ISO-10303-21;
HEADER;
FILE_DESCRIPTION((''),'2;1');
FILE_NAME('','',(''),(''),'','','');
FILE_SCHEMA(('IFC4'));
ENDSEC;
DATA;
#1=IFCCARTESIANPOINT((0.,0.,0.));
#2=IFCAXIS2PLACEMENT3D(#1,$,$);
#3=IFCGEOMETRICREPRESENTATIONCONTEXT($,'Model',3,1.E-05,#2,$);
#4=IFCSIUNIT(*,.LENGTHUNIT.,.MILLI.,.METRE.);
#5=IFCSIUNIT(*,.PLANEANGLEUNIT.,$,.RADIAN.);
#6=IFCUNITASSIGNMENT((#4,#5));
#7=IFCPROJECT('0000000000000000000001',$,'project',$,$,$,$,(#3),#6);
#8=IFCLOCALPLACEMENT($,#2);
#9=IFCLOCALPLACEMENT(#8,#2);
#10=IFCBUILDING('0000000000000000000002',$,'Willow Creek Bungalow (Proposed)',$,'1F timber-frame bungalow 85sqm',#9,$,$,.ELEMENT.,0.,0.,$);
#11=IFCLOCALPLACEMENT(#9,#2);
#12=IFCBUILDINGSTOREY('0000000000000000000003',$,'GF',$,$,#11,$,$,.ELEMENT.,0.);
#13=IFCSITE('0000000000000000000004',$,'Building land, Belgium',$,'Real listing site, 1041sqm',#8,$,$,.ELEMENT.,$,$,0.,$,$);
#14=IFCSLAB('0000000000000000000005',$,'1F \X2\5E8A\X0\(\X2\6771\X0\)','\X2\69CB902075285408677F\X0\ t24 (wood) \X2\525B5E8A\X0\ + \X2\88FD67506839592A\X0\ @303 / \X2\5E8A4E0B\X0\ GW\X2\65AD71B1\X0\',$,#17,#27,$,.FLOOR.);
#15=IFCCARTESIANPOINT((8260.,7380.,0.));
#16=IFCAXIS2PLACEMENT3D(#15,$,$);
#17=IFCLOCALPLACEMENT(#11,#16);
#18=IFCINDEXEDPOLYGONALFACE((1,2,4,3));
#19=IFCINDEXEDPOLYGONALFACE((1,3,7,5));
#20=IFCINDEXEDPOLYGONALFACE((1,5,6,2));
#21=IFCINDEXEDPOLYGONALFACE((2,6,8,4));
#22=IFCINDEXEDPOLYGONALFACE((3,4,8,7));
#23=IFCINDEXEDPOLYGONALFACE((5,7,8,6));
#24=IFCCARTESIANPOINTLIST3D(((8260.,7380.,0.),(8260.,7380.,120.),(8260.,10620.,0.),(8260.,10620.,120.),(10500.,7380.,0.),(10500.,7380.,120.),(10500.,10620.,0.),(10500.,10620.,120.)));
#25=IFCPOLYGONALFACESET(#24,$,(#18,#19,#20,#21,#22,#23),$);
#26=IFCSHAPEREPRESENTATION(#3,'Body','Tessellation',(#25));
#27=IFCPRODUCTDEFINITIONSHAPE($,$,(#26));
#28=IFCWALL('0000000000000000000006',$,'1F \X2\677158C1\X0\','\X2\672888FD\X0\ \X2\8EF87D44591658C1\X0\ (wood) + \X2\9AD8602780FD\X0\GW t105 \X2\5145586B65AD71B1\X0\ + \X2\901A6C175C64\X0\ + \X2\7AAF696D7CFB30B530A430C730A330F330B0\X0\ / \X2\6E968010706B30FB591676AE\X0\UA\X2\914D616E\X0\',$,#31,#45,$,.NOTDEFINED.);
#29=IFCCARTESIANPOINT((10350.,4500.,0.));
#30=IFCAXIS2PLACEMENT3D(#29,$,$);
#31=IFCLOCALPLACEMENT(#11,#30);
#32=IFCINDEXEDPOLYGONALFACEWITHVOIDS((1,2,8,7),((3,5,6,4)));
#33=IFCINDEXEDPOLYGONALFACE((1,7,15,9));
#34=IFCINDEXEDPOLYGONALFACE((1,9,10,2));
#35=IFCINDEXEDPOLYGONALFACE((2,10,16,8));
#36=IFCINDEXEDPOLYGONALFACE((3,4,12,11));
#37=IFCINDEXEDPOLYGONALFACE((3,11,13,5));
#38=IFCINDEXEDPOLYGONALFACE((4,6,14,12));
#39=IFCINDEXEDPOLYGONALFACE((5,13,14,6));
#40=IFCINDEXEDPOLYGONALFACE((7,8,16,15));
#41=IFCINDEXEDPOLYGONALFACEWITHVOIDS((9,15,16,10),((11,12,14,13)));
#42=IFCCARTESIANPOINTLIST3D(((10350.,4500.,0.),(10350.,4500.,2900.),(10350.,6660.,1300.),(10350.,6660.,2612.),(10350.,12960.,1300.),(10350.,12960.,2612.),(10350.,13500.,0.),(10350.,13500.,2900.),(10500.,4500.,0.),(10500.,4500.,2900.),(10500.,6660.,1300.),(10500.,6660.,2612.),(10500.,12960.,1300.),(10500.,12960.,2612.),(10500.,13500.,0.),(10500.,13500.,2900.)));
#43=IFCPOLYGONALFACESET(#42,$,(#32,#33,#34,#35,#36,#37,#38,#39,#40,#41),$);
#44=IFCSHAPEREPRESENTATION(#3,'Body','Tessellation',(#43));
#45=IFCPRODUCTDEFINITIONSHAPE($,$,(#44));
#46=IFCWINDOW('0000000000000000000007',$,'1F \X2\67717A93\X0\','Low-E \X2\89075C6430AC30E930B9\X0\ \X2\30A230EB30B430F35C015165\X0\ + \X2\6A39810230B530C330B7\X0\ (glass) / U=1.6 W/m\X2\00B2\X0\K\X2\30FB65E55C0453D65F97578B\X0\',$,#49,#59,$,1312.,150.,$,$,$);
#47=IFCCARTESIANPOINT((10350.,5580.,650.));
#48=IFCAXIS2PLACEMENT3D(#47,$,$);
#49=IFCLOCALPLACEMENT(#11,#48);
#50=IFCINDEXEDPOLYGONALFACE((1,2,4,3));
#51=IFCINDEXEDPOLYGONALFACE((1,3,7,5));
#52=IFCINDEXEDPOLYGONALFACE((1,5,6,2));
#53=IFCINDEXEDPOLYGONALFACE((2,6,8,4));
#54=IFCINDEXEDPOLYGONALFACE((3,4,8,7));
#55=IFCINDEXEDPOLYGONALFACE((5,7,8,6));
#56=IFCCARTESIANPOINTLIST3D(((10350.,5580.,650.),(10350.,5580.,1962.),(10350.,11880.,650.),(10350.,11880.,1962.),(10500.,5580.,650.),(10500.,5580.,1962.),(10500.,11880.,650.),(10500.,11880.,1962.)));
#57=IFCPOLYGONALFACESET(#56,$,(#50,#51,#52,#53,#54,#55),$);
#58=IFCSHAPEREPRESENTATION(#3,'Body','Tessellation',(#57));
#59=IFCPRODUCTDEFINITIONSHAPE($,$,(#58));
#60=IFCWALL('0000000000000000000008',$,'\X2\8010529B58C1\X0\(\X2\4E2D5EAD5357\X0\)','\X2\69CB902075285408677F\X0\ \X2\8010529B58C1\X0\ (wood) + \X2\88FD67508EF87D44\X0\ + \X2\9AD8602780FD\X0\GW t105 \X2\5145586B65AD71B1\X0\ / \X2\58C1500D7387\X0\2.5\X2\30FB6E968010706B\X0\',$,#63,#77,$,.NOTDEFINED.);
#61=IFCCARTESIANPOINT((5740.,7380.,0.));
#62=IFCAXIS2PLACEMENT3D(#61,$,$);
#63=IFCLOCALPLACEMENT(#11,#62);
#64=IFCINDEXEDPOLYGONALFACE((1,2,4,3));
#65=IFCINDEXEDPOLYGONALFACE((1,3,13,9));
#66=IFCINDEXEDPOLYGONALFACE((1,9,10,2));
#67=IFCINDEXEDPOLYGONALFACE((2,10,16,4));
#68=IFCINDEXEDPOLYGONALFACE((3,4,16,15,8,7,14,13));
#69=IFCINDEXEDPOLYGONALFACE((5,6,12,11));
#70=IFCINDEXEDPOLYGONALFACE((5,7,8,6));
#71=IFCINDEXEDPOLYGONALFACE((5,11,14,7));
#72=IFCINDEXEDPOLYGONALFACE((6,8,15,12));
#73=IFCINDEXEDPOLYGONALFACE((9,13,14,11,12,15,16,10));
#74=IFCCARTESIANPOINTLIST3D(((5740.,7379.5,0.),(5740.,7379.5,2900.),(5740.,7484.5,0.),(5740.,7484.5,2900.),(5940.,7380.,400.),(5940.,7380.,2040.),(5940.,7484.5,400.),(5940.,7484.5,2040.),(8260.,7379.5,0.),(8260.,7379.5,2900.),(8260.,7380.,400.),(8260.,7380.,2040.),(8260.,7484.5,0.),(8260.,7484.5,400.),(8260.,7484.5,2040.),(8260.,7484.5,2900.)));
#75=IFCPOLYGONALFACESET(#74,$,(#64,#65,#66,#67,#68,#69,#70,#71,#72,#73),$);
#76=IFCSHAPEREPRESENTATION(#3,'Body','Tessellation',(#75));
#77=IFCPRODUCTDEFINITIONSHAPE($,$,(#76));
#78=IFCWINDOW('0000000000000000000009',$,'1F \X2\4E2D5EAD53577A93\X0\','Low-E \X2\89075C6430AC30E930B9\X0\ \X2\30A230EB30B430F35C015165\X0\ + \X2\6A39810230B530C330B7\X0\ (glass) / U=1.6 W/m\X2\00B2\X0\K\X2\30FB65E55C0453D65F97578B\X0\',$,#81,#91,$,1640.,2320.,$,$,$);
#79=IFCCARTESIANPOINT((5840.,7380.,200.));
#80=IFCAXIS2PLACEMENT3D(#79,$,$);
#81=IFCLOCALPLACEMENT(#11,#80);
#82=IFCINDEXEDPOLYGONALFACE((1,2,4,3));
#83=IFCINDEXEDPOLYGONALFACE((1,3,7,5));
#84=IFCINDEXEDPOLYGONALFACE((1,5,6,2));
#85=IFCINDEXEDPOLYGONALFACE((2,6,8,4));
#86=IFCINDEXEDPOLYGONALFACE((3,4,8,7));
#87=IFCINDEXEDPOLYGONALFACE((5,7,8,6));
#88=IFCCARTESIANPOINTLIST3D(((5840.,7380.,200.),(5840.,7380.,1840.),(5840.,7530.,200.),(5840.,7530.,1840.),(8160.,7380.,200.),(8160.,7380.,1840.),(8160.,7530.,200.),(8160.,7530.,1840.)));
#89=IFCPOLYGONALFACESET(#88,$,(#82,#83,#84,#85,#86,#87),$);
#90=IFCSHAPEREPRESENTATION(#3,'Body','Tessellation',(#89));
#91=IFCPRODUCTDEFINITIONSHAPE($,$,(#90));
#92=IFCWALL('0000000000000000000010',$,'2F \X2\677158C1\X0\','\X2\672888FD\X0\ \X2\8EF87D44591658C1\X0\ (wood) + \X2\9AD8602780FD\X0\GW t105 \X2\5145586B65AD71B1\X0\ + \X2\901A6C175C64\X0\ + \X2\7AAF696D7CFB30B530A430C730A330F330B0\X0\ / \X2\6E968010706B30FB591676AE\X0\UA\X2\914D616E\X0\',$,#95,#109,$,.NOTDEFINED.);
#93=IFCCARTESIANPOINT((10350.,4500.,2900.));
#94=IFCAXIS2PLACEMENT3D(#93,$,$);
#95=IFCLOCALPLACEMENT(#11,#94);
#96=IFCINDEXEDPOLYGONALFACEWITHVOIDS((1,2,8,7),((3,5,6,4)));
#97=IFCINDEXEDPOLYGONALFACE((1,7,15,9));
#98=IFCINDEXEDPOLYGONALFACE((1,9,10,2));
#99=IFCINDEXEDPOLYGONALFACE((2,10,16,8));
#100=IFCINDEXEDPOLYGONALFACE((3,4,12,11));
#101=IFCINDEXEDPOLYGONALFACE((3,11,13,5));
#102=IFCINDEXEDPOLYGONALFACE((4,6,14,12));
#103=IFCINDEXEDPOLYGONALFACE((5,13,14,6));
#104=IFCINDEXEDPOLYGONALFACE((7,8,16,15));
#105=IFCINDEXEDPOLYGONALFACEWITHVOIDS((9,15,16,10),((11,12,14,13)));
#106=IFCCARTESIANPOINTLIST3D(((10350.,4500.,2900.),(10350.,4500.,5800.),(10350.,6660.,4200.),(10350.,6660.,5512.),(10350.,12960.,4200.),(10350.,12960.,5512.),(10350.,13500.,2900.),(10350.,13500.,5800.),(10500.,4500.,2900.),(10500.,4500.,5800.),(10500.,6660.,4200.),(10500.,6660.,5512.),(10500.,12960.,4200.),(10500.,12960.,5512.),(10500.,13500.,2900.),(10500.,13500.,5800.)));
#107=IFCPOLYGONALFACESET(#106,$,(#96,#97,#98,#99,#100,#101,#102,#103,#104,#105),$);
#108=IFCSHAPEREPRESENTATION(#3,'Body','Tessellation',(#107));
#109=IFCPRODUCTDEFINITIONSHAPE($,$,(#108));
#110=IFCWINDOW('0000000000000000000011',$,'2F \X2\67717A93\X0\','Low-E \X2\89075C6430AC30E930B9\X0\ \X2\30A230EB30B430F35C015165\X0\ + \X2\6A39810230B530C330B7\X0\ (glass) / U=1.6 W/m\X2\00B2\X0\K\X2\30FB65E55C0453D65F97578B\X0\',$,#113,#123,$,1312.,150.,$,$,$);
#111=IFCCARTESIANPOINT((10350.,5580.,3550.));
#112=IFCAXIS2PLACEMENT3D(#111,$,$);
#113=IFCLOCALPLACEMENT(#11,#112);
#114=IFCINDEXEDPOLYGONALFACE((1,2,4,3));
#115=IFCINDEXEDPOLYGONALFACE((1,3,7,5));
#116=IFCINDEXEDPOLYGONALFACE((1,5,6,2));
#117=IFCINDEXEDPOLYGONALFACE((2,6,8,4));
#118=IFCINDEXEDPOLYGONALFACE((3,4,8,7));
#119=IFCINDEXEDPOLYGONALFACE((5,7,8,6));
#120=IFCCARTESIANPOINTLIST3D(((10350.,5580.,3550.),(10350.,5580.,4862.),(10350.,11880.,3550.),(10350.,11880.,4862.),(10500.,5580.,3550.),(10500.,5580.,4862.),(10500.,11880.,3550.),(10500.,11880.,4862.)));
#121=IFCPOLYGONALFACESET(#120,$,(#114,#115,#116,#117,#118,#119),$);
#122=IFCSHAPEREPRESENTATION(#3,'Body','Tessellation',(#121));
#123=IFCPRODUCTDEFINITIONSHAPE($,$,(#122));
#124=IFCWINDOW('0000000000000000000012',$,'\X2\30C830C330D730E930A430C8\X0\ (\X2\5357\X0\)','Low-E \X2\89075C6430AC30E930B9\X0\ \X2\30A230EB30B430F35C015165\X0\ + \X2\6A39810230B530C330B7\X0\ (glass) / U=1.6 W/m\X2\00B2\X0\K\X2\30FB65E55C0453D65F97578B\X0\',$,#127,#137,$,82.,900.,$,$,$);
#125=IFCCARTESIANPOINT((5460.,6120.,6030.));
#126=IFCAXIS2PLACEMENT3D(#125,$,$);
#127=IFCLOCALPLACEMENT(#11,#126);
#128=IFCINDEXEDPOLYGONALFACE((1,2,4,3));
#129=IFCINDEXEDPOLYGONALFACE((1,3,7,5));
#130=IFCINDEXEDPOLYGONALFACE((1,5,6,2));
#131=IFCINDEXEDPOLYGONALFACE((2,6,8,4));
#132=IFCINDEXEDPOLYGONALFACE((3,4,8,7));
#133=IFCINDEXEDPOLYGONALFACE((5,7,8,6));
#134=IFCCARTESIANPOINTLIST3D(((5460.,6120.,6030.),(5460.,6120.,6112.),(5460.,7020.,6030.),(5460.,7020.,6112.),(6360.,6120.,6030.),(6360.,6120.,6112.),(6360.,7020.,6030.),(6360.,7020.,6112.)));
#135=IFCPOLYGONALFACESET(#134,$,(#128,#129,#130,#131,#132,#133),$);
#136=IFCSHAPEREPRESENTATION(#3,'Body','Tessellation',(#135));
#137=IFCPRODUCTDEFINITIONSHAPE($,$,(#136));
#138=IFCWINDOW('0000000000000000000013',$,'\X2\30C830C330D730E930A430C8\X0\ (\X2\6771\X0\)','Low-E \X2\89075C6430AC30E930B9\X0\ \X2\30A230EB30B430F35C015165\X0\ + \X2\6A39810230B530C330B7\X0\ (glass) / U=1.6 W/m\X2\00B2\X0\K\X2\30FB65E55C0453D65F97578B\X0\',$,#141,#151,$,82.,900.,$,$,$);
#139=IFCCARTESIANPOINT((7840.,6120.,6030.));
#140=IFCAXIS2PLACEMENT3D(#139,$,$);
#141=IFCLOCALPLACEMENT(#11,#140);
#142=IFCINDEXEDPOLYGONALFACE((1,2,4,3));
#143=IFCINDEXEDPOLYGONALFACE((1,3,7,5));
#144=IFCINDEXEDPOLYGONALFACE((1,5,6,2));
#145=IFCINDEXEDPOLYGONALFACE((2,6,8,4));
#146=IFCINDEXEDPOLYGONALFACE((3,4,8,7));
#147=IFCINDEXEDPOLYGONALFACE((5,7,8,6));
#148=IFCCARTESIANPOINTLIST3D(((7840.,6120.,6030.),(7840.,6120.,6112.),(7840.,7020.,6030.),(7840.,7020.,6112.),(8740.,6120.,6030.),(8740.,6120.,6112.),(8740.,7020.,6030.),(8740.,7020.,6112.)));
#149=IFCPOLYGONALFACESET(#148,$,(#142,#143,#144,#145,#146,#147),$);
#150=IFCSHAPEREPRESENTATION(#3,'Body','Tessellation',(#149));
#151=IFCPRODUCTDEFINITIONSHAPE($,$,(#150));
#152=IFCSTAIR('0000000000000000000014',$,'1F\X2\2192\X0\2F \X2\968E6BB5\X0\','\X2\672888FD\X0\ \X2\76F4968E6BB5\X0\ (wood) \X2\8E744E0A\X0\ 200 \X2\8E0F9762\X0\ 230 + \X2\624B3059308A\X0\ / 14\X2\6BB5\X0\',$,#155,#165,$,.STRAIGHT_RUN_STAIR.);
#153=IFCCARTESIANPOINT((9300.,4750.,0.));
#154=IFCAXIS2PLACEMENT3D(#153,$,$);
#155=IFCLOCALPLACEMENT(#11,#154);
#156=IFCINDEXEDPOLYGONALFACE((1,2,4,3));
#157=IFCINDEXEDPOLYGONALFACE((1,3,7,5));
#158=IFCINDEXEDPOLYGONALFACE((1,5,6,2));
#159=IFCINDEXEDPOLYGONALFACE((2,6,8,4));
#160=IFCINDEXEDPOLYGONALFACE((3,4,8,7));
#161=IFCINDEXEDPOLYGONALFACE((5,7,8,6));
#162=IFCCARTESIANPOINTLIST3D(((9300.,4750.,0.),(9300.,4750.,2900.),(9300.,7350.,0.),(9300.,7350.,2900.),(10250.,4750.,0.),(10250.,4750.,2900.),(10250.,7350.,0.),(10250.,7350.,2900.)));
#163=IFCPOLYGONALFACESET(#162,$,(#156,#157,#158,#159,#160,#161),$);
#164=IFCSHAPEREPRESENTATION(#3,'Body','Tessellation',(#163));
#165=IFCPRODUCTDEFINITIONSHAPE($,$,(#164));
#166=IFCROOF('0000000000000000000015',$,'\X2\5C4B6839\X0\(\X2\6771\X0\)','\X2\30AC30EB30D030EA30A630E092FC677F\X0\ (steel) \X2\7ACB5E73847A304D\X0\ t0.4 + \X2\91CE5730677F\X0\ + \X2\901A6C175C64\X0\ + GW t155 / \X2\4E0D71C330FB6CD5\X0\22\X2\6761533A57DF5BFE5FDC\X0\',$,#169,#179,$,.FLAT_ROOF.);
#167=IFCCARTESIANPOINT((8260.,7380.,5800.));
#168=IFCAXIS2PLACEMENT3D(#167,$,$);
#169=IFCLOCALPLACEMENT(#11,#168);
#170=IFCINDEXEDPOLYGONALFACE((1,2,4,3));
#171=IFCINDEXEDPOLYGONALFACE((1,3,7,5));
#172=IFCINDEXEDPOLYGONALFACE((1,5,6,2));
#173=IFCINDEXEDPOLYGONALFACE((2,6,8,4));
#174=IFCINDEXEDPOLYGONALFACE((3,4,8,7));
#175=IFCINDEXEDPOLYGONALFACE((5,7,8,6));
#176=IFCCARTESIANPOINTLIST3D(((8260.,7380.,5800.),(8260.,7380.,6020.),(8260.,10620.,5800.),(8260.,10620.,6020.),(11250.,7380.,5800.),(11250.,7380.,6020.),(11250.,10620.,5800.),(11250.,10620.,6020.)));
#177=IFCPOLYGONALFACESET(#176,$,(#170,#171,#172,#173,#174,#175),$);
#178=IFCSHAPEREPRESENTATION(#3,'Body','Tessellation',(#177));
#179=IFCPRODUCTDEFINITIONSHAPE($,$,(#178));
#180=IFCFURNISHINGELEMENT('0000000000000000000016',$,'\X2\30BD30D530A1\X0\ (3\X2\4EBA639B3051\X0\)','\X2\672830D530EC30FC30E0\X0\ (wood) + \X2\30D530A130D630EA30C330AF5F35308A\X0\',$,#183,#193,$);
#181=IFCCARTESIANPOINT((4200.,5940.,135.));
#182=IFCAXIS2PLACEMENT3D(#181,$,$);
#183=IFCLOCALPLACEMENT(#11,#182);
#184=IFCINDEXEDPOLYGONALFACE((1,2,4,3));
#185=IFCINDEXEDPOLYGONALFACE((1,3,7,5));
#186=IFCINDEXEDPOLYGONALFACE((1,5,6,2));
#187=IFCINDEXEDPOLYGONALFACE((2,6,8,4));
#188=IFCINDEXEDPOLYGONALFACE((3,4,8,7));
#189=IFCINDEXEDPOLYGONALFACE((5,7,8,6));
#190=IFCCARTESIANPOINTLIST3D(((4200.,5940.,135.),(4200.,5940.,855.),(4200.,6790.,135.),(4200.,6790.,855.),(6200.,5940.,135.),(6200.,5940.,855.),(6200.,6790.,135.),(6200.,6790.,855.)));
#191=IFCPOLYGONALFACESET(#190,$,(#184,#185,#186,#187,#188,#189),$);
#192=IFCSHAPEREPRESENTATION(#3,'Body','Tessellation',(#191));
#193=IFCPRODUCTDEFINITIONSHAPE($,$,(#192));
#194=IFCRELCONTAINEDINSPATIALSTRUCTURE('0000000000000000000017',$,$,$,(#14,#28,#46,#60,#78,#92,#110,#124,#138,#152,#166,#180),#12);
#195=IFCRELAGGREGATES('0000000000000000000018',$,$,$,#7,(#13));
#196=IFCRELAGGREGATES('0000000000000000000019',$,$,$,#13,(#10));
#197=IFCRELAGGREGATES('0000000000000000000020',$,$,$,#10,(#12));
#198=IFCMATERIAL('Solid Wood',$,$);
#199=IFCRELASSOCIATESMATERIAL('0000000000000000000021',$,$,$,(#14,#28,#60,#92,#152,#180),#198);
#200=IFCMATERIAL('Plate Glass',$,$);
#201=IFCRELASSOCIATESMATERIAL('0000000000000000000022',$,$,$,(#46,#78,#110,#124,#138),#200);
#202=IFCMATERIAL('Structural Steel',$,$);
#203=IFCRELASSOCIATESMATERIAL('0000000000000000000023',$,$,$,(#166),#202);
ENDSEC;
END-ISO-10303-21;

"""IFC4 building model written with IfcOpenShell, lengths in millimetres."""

from ifc_helpers import new_model, si_unit, frame, frame_2d, origin, place, context, project, spatial, rectangle, extrude, material, element, fill, save


model = new_model("IFC4")

# Units and contexts
model_context = context("Model", 3, precision=1e-05, world=origin())
ifc_project = project(units=[si_unit("LENGTHUNIT", "METRE", prefix="MILLI"), si_unit("PLANEANGLEUNIT", "RADIAN")], contexts=[model_context])

# Site, building, storey
site_placement = place(None, origin())
site = spatial("IfcSite", under=ifc_project, at=site_placement, Name="Building land, Belgium", ObjectType="Real listing site, 1041sqm", CompositionType="ELEMENT", RefElevation=0.0)
building_placement = place(site_placement, origin())
building = spatial("IfcBuilding", under=site, at=building_placement, Name="Willow Creek Bungalow (Proposed)", ObjectType="1F timber-frame bungalow 85sqm", CompositionType="ELEMENT", ElevationOfRefHeight=0.0, ElevationOfTerrain=0.0)
storey_placement = place(building_placement, origin())
storey = spatial("IfcBuildingStorey", under=building, at=storey_placement, Name="GF", CompositionType="ELEMENT", Elevation=0.0)

# Slab
ifc_material_1 = material(Name="Solid Wood")
slab_placement = place(storey_placement, frame((8260.0, 7380.0, 0.0)))
element("IfcSlab", 1, at=slab_placement, inside=storey, material=ifc_material_1, Name="1F 床(東)", Description="構造用合板 t24 (wood) 剛床 + 製材根太 @303 / 床下 GW断熱", PredefinedType="FLOOR", context=model_context, shape_type="SweptSolid", body=[
    extrude(rectangle(XDim=2240.0, YDim=3240.0, at=frame_2d((1120.0, 1620.0))), frame((8260.0, 7380.0, 0.0)), (0.0, 0.0, 1.0), 120.0),
])

# Walls, openings, windows
wall_1_placement = place(storey_placement, frame((10350.0, 4500.0, 0.0)))
wall_1 = element("IfcWall", 2, at=wall_1_placement, inside=storey, material=ifc_material_1, Name="1F 東壁", Description="木製 軸組外壁 (wood) + 高性能GW t105 充填断熱 + 通気層 + 窯業系サイディング / 準耐火・外皮UA配慮", PredefinedType="NOTDEFINED", context=model_context, shape_type="SweptSolid", body=[
    extrude(rectangle(XDim=150.0, YDim=9000.0, at=frame_2d((75.0, 4500.0))), frame((10350.0, 4500.0, 0.0)), (0.0, 0.0, 1.0), 2900.0),
])
opening_1_placement = place(storey_placement, frame((10350.0, 5580.0, 650.0)))
opening_1 = element("IfcOpeningElement", 3, at=opening_1_placement, cuts=wall_1, PredefinedType="NOTDEFINED", context=model_context, shape_type="SweptSolid", body=[
    extrude(rectangle(XDim=150.0, YDim=6300.0, at=frame_2d((75.0, 3150.0))), frame((10350.0, 5580.0, 650.0)), (0.0, 0.0, 1.0), 1312.0),
])
ifc_material_2 = material(Name="Plate Glass")
window_1_placement = place(storey_placement, frame((10350.0, 5580.0, 650.0)))
window_1 = element("IfcWindow", 4, at=window_1_placement, inside=storey, material=ifc_material_2, Name="1F 東窓", Description="Low-E 複層ガラス アルゴン封入 + 樹脂サッシ (glass) / U=1.6 W/m²K・日射取得型", OverallHeight=1312.0, OverallWidth=150.0, context=model_context, shape_type="SweptSolid", body=[
    extrude(rectangle(XDim=150.0, YDim=6300.0, at=frame_2d((75.0, 3150.0))), frame((10350.0, 5580.0, 650.0)), (0.0, 0.0, 1.0), 1312.0),
])
fill(opening_1, window_1)
wall_2_placement = place(storey_placement, frame((5740.0, 7380.0, 0.0)))
wall_2 = element("IfcWall", 5, at=wall_2_placement, inside=storey, material=ifc_material_1, Name="耐力壁(中庭南)", Description="構造用合板 耐力壁 (wood) + 製材軸組 + 高性能GW t105 充填断熱 / 壁倍率2.5・準耐火", PredefinedType="NOTDEFINED", context=model_context, shape_type="SweptSolid", body=[
    extrude(rectangle(XDim=2520.0, YDim=105.0, at=frame_2d((1260.0, 52.0))), frame((5740.0, 7380.0, 0.0)), (0.0, 0.0, 1.0), 2900.0),
])
opening_2_placement = place(storey_placement, frame((5840.0, 7380.0, 200.0)))
opening_2 = element("IfcOpeningElement", 6, at=opening_2_placement, cuts=wall_2, PredefinedType="NOTDEFINED", context=model_context, shape_type="SweptSolid", body=[
    extrude(rectangle(XDim=2320.0, YDim=150.0, at=frame_2d((1160.0, 75.0))), frame((5840.0, 7380.0, 200.0)), (0.0, 0.0, 1.0), 1640.0),
])
window_2_placement = place(storey_placement, frame((5840.0, 7380.0, 200.0)))
window_2 = element("IfcWindow", 7, at=window_2_placement, inside=storey, material=ifc_material_2, Name="1F 中庭南窓", Description="Low-E 複層ガラス アルゴン封入 + 樹脂サッシ (glass) / U=1.6 W/m²K・日射取得型", OverallHeight=1640.0, OverallWidth=2320.0, context=model_context, shape_type="SweptSolid", body=[
    extrude(rectangle(XDim=2320.0, YDim=150.0, at=frame_2d((1160.0, 75.0))), frame((5840.0, 7380.0, 200.0)), (0.0, 0.0, 1.0), 1640.0),
])
fill(opening_2, window_2)

# Wall, opening, window
wall_3_placement = place(storey_placement, frame((10350.0, 4500.0, 2900.0)))
wall_3 = element("IfcWall", 8, at=wall_3_placement, inside=storey, material=ifc_material_1, Name="2F 東壁", Description="木製 軸組外壁 (wood) + 高性能GW t105 充填断熱 + 通気層 + 窯業系サイディング / 準耐火・外皮UA配慮", PredefinedType="NOTDEFINED", context=model_context, shape_type="SweptSolid", body=[
    extrude(rectangle(XDim=150.0, YDim=9000.0, at=frame_2d((75.0, 4500.0))), frame((10350.0, 4500.0, 2900.0)), (0.0, 0.0, 1.0), 2900.0),
])
opening_3_placement = place(storey_placement, frame((10350.0, 5580.0, 3550.0)))
opening_3 = element("IfcOpeningElement", 9, at=opening_3_placement, cuts=wall_3, PredefinedType="NOTDEFINED", context=model_context, shape_type="SweptSolid", body=[
    extrude(rectangle(XDim=150.0, YDim=6300.0, at=frame_2d((75.0, 3150.0))), frame((10350.0, 5580.0, 3550.0)), (0.0, 0.0, 1.0), 1312.0),
])
window_3_placement = place(storey_placement, frame((10350.0, 5580.0, 3550.0)))
window_3 = element("IfcWindow", 10, at=window_3_placement, inside=storey, material=ifc_material_2, Name="2F 東窓", Description="Low-E 複層ガラス アルゴン封入 + 樹脂サッシ (glass) / U=1.6 W/m²K・日射取得型", OverallHeight=1312.0, OverallWidth=150.0, context=model_context, shape_type="SweptSolid", body=[
    extrude(rectangle(XDim=150.0, YDim=6300.0, at=frame_2d((75.0, 3150.0))), frame((10350.0, 5580.0, 3550.0)), (0.0, 0.0, 1.0), 1312.0),
])
fill(opening_3, window_3)

# Windows
window_4_placement = place(storey_placement, frame((5460.0, 6120.0, 6030.0)))
element("IfcWindow", 11, at=window_4_placement, inside=storey, material=ifc_material_2, Name="トップライト (南)", Description="Low-E 複層ガラス アルゴン封入 + 樹脂サッシ (glass) / U=1.6 W/m²K・日射取得型", OverallHeight=82.0, OverallWidth=900.0, context=model_context, shape_type="SweptSolid", body=[
    extrude(rectangle(XDim=900.0, YDim=900.0, at=frame_2d((450.0, 450.0))), frame((5460.0, 6120.0, 6030.0)), (0.0, 0.0, 1.0), 82.0),
])
window_5_placement = place(storey_placement, frame((7840.0, 6120.0, 6030.0)))
element("IfcWindow", 12, at=window_5_placement, inside=storey, material=ifc_material_2, Name="トップライト (東)", Description="Low-E 複層ガラス アルゴン封入 + 樹脂サッシ (glass) / U=1.6 W/m²K・日射取得型", OverallHeight=82.0, OverallWidth=900.0, context=model_context, shape_type="SweptSolid", body=[
    extrude(rectangle(XDim=900.0, YDim=900.0, at=frame_2d((450.0, 450.0))), frame((7840.0, 6120.0, 6030.0)), (0.0, 0.0, 1.0), 82.0),
])

# Stair
stair_placement = place(storey_placement, frame((9300.0, 4750.0, 0.0)))
element("IfcStair", 13, at=stair_placement, inside=storey, material=ifc_material_1, Name="1F→2F 階段", Description="木製 直階段 (wood) 蹴上 200 踏面 230 + 手すり / 14段", PredefinedType="STRAIGHT_RUN_STAIR", context=model_context, shape_type="SweptSolid", body=[
    extrude(rectangle(XDim=950.0, YDim=2600.0, at=frame_2d((475.0, 1300.0))), frame((9300.0, 4750.0, 0.0)), (0.0, 0.0, 1.0), 2900.0),
])

# Roof
ifc_material_3 = material(Name="Structural Steel")
roof_placement = place(storey_placement, frame((8260.0, 7380.0, 5800.0)))
element("IfcRoof", 14, at=roof_placement, inside=storey, material=ifc_material_3, Name="屋根(東)", Description="ガルバリウム鋼板 (steel) 立平葺き t0.4 + 野地板 + 通気層 + GW t155 / 不燃・法22条区域対応", PredefinedType="FLAT_ROOF", context=model_context, shape_type="SweptSolid", body=[
    extrude(rectangle(XDim=2990.0, YDim=3240.0, at=frame_2d((1495.0, 1620.0))), frame((8260.0, 7380.0, 5800.0)), (0.0, 0.0, 1.0), 220.0),
])

# Furnishing element
furnishing_1_placement = place(storey_placement, frame((4200.0, 5940.0, 135.0)))
element("IfcFurnishingElement", 15, at=furnishing_1_placement, inside=storey, material=ifc_material_1, Name="ソファ (3人掛け)", Description="木フレーム (wood) + ファブリック張り", context=model_context, shape_type="SweptSolid", body=[
    extrude(rectangle(XDim=2000.0, YDim=850.0, at=frame_2d((1000.0, 425.0))), frame((4200.0, 5940.0, 135.0)), (0.0, 0.0, 1.0), 720.0),
])

save(model, "model.ifc")
